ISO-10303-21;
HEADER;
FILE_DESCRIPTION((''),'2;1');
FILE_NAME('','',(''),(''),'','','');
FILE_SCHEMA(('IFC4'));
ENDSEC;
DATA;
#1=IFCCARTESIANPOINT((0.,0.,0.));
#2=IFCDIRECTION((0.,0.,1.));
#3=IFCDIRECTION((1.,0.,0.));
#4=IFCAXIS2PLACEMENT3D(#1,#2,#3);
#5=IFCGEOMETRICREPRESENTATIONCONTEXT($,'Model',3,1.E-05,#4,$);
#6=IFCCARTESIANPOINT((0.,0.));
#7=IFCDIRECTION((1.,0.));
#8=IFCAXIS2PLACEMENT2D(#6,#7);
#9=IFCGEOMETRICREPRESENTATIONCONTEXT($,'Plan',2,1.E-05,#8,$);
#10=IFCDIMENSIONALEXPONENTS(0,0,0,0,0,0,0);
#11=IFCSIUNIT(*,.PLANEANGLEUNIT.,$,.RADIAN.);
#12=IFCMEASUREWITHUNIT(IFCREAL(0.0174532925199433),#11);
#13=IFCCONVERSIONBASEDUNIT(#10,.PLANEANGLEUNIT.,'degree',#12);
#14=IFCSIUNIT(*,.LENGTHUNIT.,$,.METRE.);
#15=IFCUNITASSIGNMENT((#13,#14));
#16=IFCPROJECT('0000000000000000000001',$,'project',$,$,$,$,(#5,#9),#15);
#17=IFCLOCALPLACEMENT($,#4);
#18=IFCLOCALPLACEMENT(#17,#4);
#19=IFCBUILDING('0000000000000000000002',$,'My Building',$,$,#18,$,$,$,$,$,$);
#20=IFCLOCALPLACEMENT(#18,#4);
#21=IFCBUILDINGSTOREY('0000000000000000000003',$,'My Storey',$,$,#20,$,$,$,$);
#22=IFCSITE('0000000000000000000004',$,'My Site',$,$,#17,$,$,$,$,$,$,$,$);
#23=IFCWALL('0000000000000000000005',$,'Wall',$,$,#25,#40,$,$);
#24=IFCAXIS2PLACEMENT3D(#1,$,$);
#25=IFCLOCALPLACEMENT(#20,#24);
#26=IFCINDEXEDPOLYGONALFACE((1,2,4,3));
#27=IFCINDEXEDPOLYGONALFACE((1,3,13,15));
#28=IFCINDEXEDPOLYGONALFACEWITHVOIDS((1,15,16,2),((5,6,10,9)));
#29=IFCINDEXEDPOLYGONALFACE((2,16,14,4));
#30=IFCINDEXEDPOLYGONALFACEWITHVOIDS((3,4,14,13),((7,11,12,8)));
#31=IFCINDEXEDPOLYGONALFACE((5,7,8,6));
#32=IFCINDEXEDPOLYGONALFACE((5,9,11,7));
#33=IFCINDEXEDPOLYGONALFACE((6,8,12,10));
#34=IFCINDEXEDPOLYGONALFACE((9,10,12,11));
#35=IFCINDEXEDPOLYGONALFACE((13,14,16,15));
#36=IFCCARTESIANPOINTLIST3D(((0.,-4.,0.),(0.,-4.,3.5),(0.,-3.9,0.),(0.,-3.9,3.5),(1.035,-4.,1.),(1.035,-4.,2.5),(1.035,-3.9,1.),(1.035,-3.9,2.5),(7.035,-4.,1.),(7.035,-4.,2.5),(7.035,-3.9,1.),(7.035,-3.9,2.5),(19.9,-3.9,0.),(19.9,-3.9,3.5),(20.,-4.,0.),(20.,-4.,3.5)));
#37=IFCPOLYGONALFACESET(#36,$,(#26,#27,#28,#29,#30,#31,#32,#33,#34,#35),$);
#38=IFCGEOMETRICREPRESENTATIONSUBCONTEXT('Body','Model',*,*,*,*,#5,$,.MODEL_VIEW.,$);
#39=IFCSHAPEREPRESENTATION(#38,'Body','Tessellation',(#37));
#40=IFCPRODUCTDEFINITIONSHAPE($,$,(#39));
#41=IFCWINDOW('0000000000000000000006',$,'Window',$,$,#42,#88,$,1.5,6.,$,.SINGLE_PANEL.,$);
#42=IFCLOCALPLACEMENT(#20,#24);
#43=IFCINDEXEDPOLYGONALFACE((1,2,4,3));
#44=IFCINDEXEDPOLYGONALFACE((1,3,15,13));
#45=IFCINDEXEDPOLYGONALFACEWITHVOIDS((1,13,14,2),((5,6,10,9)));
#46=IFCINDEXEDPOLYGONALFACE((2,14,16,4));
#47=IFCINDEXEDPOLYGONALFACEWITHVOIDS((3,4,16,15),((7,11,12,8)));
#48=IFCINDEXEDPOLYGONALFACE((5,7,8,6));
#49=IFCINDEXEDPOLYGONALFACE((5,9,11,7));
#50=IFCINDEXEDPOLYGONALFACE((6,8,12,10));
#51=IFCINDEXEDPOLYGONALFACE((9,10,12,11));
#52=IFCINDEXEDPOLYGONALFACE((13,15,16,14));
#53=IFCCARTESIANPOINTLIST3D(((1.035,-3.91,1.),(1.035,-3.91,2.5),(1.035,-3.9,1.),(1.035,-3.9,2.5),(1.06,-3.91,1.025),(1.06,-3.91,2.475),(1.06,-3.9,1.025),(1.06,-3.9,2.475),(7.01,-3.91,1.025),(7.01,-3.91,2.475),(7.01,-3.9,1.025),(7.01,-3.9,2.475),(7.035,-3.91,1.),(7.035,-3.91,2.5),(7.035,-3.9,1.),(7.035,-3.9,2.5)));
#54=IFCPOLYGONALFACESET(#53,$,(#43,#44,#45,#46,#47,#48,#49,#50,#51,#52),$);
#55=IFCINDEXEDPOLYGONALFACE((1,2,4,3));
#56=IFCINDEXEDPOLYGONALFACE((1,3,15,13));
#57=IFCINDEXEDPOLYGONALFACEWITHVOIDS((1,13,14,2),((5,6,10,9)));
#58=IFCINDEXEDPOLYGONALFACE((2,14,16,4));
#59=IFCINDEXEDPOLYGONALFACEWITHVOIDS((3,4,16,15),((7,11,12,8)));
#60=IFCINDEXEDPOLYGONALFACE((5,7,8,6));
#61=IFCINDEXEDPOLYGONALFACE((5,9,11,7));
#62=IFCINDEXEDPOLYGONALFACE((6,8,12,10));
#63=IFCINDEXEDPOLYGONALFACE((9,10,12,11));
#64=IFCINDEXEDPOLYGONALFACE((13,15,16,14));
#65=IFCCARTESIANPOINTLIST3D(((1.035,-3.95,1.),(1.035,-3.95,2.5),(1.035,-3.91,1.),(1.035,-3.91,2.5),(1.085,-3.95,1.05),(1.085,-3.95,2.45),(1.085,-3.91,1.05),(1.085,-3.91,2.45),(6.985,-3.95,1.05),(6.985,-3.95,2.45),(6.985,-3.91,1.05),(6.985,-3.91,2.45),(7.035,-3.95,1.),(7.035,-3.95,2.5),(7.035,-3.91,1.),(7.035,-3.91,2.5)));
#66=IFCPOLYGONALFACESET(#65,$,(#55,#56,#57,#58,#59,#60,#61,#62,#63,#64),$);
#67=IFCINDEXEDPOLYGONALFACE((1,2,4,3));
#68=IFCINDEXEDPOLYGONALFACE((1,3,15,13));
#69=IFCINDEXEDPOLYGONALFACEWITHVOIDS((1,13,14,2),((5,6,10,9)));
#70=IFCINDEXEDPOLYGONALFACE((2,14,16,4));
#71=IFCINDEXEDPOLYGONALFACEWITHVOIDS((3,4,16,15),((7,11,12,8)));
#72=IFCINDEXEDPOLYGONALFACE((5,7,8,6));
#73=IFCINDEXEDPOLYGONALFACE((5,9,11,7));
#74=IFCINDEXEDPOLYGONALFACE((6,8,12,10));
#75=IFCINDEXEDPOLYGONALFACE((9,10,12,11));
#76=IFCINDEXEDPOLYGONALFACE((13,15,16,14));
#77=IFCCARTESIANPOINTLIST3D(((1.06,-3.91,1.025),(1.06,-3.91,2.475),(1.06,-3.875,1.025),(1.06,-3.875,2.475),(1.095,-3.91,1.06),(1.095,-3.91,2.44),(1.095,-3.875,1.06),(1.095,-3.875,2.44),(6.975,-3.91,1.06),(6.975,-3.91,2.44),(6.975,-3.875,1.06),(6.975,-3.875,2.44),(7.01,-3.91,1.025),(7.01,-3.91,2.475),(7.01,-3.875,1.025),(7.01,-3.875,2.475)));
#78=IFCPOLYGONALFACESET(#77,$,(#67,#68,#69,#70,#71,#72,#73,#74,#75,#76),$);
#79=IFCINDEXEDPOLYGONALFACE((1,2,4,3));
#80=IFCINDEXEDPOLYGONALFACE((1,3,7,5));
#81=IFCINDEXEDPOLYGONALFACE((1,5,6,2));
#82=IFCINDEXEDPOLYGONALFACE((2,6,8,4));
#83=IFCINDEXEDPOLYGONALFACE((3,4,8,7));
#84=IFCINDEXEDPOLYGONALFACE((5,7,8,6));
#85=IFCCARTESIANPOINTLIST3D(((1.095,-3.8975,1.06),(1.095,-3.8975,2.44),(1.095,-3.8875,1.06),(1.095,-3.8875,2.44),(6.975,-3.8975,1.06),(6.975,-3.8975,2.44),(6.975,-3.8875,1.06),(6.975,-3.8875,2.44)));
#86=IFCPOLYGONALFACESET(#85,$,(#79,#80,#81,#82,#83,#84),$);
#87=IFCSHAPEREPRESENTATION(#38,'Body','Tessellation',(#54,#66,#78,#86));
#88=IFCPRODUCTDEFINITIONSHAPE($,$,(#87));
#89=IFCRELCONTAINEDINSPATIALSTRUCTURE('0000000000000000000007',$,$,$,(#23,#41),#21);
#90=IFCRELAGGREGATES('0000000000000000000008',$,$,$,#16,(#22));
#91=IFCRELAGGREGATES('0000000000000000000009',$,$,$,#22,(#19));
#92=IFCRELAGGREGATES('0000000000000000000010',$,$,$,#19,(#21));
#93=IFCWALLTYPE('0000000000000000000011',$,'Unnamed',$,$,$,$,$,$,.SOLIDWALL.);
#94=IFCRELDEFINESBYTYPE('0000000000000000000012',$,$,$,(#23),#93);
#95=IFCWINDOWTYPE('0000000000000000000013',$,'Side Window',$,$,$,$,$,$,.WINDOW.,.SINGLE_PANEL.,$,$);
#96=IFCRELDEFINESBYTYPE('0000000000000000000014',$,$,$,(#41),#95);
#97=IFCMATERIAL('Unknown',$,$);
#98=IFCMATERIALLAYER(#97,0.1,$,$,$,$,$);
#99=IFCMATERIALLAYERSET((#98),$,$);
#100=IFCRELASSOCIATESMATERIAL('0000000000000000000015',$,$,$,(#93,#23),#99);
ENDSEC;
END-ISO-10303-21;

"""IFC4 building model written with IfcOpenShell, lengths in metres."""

from ifc_helpers import new_model, entity, si_unit, converted_unit, frame, origin_with_axes, origin_2d_with_axis, place, context, subcontext, project, spatial, line, indexed_curve, outline, extrude, shape, source, transform, mapped, material, layer, layer_set, layer_usage, type_object, type_shapes, element, fill, save


model = new_model("IFC4")

# Units and contexts
model_context = context("Model", 3, precision=1e-05, world=origin_with_axes())
plan_context = context("Plan", 2, precision=1e-05, world=origin_2d_with_axis())
body_context_1 = subcontext(model_context, "Body", "Model", "MODEL_VIEW")
body_context_2 = subcontext(plan_context, "Body", "Plan", "PLAN_VIEW")
ifc_project = project(units=[converted_unit("PLANEANGLEUNIT", "degree", entity("IfcReal", 0.0174532925199433), si_unit("PLANEANGLEUNIT", "RADIAN"), dimensions=[0, 0, 0, 0, 0, 0, 0]), si_unit("LENGTHUNIT", "METRE")], contexts=[model_context, plan_context])

# Site, building, storey
site_placement = place(None, origin_with_axes())
site = spatial("IfcSite", under=ifc_project, at=site_placement, Name="My Site")
building_placement = place(site_placement, origin_with_axes())
building = spatial("IfcBuilding", under=site, at=building_placement, Name="My Building")
storey_placement = place(building_placement, origin_with_axes())
storey = spatial("IfcBuildingStorey", under=building, at=storey_placement, Name="My Storey")

# Shared definitions
ifc_material = material(Name="Unknown")

# Wall, opening, window
ifc_layer_1 = layer(ifc_material, 0.1)
ifc_layer_set_1 = layer_set([ifc_layer_1])
ifc_layer_usage_1 = layer_usage(ifc_layer_set_1, "AXIS2", "POSITIVE", 0.0)
wall_type = type_object("IfcWallType", Name="Unnamed", PredefinedType="SOLIDWALL", material=ifc_layer_set_1)
wall_placement = place(storey_placement, frame((0.0, -4.0, 0.0), z_axis=(0.0, 0.0, 1.0), x_axis=(1.0, 0.0, 0.0)))
wall = element("IfcWall", 1, at=wall_placement, inside=storey, type_object=wall_type, material=ifc_layer_usage_1, Name="Wall", context=body_context_1, shape_type="SweptSolid", body=[
    extrude(outline(indexed_curve([(0.0, 0.0), (0.0, 0.1), (19.9, 0.1), (20.0, 0.0)], segments=[line(1, 2, 3, 4, 1)])), origin_with_axes(), (0.0, 0.0, 1.0), 3.5),
])
shared_shape_1 = source(origin_with_axes(), body_context_1, "Body", "SweptSolid", [
    extrude(outline(indexed_curve([(0.0, 0.0), (6.0, 0.0), (6.0, 1.5), (0.0, 1.5)], segments=[line(1, 2, 3, 4, 1)])), frame((0.0, -0.6, 0.0), z_axis=(0.0, -1.0, 0.0), x_axis=(1.0, 0.0, 0.0)), (0.0, 0.0, -1.0), 1.2),
])
opening_placement = place(wall_placement, frame((1.035, 0.0, 1.0), z_axis=(0.0, 0.0, 1.0), x_axis=(1.0, 0.0, 0.0)))
opening = element("IfcOpeningElement", 2, at=opening_placement, cuts=wall, PredefinedType="OPENING", context=body_context_1, shape_type="MappedRepresentation", body=[
    mapped(shared_shape_1, transform((0.0, 0.0, 0.0), x_axis=(1.0, 0.0, 0.0), y_axis=(0.0, 1.0, 0.0), z_axis=(0.0, 0.0, 1.0), scale=1.0)),
])
window_type_1 = type_object("IfcWindowType", Name="Side Window", PartitioningType="SINGLE_PANEL", PredefinedType="WINDOW")
shared_shape_2 = source(origin_with_axes(), body_context_1, "Body", "SweptSolid", [
    extrude(outline(indexed_curve([(0.0, 0.0), (6.0, 0.0), (6.0, 1.5), (0.0, 1.5)], segments=[line(1, 2, 3, 4, 1)]), holes=[indexed_curve([(0.025, 0.025), (5.975, 0.025), (5.975, 1.475), (0.025, 1.475)], segments=[line(1, 2, 3, 4, 1)])]), frame((0.0, 0.09, 0.0), z_axis=(0.0, -1.0, 0.0), x_axis=(1.0, 0.0, 0.0)), (0.0, 0.0, -1.0), 0.01),
    extrude(outline(indexed_curve([(0.0, 0.0), (6.0, 0.0), (6.0, 1.5), (0.0, 1.5)], segments=[line(1, 2, 3, 4, 1)]), holes=[indexed_curve([(0.05, 0.05), (5.95, 0.05), (5.95, 1.45), (0.05, 1.45)], segments=[line(1, 2, 3, 4, 1)])]), frame((0.0, 0.05, 0.0), z_axis=(0.0, -1.0, 0.0), x_axis=(1.0, 0.0, 0.0)), (0.0, 0.0, -1.0), 0.04),
    extrude(outline(indexed_curve([(0.0, 0.0), (5.95, 0.0), (5.95, 1.45), (0.0, 1.45)], segments=[line(1, 2, 3, 4, 1)]), holes=[indexed_curve([(0.035, 0.035), (5.915, 0.035), (5.915, 1.415), (0.035, 1.415)], segments=[line(1, 2, 3, 4, 1)])]), frame((0.025, 0.09, 0.025), z_axis=(0.0, -1.0, 0.0), x_axis=(1.0, 0.0, 0.0)), (0.0, 0.0, -1.0), 0.035),
    extrude(outline(indexed_curve([(0.035, 0.035), (5.915, 0.035), (5.915, 1.415), (0.035, 1.415)], segments=[line(1, 2, 3, 4, 1)])), frame((0.025, 0.1025, 0.025), z_axis=(0.0, -1.0, 0.0), x_axis=(1.0, 0.0, 0.0)), (0.0, 0.0, -1.0), 0.01),
])
shared_shape_3 = source(origin_with_axes(), body_context_2, "Body", "Curve2D", [
    entity("IfcIndexedPolyCurve", entity("IfcCartesianPointList2D", [[0.05, 0.05], [5.95, 0.05]])),
    entity("IfcIndexedPolyCurve", entity("IfcCartesianPointList2D", [[0.0, 0.1], [0.025, 0.1], [0.025, 0.09], [0.05, 0.09], [0.05, 0.05], [0.0, 0.05]]), [entity("IfcLineIndex", [1, 2, 3, 4, 5, 6, 1])]),
    entity("IfcIndexedPolyCurve", entity("IfcCartesianPointList2D", [[6.0, 0.1], [5.975, 0.1], [5.975, 0.09], [5.95, 0.09], [5.95, 0.05], [6.0, 0.05]]), [entity("IfcLineIndex", [1, 2, 3, 4, 5, 6, 1])]),
    entity("IfcIndexedPolyCurve", entity("IfcCartesianPointList2D", [[0.025, 0.09], [0.06, 0.09], [0.06, 0.125], [0.025, 0.125]]), [entity("IfcLineIndex", [1, 2, 3, 4, 1])]),
    entity("IfcIndexedPolyCurve", entity("IfcCartesianPointList2D", [[5.975, 0.09], [5.94, 0.09], [5.94, 0.125], [5.975, 0.125]]), [entity("IfcLineIndex", [1, 2, 3, 4, 1])]),
    entity("IfcIndexedPolyCurve", entity("IfcCartesianPointList2D", [[0.06, 0.09], [5.94, 0.09]])),
    entity("IfcIndexedPolyCurve", entity("IfcCartesianPointList2D", [[0.06, 0.125], [5.94, 0.125]])),
    entity("IfcIndexedPolyCurve", entity("IfcCartesianPointList2D", [[0.06, 0.1075], [5.94, 0.1075]])),
])
type_shapes(window_type_1, [shared_shape_2, shared_shape_3])
window_1_placement = place(opening_placement, origin_with_axes())
window_1 = element("IfcWindow", 3, at=window_1_placement, inside=storey, type_object=window_type_1, Name="Window", OverallHeight=1.5, OverallWidth=6.0, PartitioningType="SINGLE_PANEL", shapes=[
    shape(body_context_1, "Body", "MappedRepresentation", [mapped(shared_shape_2, transform((0.0, 0.0, 0.0), x_axis=(1.0, 0.0, 0.0), y_axis=(0.0, 1.0, 0.0), z_axis=(0.0, 0.0, 1.0), scale=1.0))]),
    shape(body_context_2, "Body", "MappedRepresentation", [mapped(shared_shape_3, transform((0.0, 0.0, 0.0), x_axis=(1.0, 0.0, 0.0), y_axis=(0.0, 1.0, 0.0), z_axis=(0.0, 0.0, 1.0), scale=1.0))]),
])
fill(opening, window_1)

save(model, "model.ifc")
